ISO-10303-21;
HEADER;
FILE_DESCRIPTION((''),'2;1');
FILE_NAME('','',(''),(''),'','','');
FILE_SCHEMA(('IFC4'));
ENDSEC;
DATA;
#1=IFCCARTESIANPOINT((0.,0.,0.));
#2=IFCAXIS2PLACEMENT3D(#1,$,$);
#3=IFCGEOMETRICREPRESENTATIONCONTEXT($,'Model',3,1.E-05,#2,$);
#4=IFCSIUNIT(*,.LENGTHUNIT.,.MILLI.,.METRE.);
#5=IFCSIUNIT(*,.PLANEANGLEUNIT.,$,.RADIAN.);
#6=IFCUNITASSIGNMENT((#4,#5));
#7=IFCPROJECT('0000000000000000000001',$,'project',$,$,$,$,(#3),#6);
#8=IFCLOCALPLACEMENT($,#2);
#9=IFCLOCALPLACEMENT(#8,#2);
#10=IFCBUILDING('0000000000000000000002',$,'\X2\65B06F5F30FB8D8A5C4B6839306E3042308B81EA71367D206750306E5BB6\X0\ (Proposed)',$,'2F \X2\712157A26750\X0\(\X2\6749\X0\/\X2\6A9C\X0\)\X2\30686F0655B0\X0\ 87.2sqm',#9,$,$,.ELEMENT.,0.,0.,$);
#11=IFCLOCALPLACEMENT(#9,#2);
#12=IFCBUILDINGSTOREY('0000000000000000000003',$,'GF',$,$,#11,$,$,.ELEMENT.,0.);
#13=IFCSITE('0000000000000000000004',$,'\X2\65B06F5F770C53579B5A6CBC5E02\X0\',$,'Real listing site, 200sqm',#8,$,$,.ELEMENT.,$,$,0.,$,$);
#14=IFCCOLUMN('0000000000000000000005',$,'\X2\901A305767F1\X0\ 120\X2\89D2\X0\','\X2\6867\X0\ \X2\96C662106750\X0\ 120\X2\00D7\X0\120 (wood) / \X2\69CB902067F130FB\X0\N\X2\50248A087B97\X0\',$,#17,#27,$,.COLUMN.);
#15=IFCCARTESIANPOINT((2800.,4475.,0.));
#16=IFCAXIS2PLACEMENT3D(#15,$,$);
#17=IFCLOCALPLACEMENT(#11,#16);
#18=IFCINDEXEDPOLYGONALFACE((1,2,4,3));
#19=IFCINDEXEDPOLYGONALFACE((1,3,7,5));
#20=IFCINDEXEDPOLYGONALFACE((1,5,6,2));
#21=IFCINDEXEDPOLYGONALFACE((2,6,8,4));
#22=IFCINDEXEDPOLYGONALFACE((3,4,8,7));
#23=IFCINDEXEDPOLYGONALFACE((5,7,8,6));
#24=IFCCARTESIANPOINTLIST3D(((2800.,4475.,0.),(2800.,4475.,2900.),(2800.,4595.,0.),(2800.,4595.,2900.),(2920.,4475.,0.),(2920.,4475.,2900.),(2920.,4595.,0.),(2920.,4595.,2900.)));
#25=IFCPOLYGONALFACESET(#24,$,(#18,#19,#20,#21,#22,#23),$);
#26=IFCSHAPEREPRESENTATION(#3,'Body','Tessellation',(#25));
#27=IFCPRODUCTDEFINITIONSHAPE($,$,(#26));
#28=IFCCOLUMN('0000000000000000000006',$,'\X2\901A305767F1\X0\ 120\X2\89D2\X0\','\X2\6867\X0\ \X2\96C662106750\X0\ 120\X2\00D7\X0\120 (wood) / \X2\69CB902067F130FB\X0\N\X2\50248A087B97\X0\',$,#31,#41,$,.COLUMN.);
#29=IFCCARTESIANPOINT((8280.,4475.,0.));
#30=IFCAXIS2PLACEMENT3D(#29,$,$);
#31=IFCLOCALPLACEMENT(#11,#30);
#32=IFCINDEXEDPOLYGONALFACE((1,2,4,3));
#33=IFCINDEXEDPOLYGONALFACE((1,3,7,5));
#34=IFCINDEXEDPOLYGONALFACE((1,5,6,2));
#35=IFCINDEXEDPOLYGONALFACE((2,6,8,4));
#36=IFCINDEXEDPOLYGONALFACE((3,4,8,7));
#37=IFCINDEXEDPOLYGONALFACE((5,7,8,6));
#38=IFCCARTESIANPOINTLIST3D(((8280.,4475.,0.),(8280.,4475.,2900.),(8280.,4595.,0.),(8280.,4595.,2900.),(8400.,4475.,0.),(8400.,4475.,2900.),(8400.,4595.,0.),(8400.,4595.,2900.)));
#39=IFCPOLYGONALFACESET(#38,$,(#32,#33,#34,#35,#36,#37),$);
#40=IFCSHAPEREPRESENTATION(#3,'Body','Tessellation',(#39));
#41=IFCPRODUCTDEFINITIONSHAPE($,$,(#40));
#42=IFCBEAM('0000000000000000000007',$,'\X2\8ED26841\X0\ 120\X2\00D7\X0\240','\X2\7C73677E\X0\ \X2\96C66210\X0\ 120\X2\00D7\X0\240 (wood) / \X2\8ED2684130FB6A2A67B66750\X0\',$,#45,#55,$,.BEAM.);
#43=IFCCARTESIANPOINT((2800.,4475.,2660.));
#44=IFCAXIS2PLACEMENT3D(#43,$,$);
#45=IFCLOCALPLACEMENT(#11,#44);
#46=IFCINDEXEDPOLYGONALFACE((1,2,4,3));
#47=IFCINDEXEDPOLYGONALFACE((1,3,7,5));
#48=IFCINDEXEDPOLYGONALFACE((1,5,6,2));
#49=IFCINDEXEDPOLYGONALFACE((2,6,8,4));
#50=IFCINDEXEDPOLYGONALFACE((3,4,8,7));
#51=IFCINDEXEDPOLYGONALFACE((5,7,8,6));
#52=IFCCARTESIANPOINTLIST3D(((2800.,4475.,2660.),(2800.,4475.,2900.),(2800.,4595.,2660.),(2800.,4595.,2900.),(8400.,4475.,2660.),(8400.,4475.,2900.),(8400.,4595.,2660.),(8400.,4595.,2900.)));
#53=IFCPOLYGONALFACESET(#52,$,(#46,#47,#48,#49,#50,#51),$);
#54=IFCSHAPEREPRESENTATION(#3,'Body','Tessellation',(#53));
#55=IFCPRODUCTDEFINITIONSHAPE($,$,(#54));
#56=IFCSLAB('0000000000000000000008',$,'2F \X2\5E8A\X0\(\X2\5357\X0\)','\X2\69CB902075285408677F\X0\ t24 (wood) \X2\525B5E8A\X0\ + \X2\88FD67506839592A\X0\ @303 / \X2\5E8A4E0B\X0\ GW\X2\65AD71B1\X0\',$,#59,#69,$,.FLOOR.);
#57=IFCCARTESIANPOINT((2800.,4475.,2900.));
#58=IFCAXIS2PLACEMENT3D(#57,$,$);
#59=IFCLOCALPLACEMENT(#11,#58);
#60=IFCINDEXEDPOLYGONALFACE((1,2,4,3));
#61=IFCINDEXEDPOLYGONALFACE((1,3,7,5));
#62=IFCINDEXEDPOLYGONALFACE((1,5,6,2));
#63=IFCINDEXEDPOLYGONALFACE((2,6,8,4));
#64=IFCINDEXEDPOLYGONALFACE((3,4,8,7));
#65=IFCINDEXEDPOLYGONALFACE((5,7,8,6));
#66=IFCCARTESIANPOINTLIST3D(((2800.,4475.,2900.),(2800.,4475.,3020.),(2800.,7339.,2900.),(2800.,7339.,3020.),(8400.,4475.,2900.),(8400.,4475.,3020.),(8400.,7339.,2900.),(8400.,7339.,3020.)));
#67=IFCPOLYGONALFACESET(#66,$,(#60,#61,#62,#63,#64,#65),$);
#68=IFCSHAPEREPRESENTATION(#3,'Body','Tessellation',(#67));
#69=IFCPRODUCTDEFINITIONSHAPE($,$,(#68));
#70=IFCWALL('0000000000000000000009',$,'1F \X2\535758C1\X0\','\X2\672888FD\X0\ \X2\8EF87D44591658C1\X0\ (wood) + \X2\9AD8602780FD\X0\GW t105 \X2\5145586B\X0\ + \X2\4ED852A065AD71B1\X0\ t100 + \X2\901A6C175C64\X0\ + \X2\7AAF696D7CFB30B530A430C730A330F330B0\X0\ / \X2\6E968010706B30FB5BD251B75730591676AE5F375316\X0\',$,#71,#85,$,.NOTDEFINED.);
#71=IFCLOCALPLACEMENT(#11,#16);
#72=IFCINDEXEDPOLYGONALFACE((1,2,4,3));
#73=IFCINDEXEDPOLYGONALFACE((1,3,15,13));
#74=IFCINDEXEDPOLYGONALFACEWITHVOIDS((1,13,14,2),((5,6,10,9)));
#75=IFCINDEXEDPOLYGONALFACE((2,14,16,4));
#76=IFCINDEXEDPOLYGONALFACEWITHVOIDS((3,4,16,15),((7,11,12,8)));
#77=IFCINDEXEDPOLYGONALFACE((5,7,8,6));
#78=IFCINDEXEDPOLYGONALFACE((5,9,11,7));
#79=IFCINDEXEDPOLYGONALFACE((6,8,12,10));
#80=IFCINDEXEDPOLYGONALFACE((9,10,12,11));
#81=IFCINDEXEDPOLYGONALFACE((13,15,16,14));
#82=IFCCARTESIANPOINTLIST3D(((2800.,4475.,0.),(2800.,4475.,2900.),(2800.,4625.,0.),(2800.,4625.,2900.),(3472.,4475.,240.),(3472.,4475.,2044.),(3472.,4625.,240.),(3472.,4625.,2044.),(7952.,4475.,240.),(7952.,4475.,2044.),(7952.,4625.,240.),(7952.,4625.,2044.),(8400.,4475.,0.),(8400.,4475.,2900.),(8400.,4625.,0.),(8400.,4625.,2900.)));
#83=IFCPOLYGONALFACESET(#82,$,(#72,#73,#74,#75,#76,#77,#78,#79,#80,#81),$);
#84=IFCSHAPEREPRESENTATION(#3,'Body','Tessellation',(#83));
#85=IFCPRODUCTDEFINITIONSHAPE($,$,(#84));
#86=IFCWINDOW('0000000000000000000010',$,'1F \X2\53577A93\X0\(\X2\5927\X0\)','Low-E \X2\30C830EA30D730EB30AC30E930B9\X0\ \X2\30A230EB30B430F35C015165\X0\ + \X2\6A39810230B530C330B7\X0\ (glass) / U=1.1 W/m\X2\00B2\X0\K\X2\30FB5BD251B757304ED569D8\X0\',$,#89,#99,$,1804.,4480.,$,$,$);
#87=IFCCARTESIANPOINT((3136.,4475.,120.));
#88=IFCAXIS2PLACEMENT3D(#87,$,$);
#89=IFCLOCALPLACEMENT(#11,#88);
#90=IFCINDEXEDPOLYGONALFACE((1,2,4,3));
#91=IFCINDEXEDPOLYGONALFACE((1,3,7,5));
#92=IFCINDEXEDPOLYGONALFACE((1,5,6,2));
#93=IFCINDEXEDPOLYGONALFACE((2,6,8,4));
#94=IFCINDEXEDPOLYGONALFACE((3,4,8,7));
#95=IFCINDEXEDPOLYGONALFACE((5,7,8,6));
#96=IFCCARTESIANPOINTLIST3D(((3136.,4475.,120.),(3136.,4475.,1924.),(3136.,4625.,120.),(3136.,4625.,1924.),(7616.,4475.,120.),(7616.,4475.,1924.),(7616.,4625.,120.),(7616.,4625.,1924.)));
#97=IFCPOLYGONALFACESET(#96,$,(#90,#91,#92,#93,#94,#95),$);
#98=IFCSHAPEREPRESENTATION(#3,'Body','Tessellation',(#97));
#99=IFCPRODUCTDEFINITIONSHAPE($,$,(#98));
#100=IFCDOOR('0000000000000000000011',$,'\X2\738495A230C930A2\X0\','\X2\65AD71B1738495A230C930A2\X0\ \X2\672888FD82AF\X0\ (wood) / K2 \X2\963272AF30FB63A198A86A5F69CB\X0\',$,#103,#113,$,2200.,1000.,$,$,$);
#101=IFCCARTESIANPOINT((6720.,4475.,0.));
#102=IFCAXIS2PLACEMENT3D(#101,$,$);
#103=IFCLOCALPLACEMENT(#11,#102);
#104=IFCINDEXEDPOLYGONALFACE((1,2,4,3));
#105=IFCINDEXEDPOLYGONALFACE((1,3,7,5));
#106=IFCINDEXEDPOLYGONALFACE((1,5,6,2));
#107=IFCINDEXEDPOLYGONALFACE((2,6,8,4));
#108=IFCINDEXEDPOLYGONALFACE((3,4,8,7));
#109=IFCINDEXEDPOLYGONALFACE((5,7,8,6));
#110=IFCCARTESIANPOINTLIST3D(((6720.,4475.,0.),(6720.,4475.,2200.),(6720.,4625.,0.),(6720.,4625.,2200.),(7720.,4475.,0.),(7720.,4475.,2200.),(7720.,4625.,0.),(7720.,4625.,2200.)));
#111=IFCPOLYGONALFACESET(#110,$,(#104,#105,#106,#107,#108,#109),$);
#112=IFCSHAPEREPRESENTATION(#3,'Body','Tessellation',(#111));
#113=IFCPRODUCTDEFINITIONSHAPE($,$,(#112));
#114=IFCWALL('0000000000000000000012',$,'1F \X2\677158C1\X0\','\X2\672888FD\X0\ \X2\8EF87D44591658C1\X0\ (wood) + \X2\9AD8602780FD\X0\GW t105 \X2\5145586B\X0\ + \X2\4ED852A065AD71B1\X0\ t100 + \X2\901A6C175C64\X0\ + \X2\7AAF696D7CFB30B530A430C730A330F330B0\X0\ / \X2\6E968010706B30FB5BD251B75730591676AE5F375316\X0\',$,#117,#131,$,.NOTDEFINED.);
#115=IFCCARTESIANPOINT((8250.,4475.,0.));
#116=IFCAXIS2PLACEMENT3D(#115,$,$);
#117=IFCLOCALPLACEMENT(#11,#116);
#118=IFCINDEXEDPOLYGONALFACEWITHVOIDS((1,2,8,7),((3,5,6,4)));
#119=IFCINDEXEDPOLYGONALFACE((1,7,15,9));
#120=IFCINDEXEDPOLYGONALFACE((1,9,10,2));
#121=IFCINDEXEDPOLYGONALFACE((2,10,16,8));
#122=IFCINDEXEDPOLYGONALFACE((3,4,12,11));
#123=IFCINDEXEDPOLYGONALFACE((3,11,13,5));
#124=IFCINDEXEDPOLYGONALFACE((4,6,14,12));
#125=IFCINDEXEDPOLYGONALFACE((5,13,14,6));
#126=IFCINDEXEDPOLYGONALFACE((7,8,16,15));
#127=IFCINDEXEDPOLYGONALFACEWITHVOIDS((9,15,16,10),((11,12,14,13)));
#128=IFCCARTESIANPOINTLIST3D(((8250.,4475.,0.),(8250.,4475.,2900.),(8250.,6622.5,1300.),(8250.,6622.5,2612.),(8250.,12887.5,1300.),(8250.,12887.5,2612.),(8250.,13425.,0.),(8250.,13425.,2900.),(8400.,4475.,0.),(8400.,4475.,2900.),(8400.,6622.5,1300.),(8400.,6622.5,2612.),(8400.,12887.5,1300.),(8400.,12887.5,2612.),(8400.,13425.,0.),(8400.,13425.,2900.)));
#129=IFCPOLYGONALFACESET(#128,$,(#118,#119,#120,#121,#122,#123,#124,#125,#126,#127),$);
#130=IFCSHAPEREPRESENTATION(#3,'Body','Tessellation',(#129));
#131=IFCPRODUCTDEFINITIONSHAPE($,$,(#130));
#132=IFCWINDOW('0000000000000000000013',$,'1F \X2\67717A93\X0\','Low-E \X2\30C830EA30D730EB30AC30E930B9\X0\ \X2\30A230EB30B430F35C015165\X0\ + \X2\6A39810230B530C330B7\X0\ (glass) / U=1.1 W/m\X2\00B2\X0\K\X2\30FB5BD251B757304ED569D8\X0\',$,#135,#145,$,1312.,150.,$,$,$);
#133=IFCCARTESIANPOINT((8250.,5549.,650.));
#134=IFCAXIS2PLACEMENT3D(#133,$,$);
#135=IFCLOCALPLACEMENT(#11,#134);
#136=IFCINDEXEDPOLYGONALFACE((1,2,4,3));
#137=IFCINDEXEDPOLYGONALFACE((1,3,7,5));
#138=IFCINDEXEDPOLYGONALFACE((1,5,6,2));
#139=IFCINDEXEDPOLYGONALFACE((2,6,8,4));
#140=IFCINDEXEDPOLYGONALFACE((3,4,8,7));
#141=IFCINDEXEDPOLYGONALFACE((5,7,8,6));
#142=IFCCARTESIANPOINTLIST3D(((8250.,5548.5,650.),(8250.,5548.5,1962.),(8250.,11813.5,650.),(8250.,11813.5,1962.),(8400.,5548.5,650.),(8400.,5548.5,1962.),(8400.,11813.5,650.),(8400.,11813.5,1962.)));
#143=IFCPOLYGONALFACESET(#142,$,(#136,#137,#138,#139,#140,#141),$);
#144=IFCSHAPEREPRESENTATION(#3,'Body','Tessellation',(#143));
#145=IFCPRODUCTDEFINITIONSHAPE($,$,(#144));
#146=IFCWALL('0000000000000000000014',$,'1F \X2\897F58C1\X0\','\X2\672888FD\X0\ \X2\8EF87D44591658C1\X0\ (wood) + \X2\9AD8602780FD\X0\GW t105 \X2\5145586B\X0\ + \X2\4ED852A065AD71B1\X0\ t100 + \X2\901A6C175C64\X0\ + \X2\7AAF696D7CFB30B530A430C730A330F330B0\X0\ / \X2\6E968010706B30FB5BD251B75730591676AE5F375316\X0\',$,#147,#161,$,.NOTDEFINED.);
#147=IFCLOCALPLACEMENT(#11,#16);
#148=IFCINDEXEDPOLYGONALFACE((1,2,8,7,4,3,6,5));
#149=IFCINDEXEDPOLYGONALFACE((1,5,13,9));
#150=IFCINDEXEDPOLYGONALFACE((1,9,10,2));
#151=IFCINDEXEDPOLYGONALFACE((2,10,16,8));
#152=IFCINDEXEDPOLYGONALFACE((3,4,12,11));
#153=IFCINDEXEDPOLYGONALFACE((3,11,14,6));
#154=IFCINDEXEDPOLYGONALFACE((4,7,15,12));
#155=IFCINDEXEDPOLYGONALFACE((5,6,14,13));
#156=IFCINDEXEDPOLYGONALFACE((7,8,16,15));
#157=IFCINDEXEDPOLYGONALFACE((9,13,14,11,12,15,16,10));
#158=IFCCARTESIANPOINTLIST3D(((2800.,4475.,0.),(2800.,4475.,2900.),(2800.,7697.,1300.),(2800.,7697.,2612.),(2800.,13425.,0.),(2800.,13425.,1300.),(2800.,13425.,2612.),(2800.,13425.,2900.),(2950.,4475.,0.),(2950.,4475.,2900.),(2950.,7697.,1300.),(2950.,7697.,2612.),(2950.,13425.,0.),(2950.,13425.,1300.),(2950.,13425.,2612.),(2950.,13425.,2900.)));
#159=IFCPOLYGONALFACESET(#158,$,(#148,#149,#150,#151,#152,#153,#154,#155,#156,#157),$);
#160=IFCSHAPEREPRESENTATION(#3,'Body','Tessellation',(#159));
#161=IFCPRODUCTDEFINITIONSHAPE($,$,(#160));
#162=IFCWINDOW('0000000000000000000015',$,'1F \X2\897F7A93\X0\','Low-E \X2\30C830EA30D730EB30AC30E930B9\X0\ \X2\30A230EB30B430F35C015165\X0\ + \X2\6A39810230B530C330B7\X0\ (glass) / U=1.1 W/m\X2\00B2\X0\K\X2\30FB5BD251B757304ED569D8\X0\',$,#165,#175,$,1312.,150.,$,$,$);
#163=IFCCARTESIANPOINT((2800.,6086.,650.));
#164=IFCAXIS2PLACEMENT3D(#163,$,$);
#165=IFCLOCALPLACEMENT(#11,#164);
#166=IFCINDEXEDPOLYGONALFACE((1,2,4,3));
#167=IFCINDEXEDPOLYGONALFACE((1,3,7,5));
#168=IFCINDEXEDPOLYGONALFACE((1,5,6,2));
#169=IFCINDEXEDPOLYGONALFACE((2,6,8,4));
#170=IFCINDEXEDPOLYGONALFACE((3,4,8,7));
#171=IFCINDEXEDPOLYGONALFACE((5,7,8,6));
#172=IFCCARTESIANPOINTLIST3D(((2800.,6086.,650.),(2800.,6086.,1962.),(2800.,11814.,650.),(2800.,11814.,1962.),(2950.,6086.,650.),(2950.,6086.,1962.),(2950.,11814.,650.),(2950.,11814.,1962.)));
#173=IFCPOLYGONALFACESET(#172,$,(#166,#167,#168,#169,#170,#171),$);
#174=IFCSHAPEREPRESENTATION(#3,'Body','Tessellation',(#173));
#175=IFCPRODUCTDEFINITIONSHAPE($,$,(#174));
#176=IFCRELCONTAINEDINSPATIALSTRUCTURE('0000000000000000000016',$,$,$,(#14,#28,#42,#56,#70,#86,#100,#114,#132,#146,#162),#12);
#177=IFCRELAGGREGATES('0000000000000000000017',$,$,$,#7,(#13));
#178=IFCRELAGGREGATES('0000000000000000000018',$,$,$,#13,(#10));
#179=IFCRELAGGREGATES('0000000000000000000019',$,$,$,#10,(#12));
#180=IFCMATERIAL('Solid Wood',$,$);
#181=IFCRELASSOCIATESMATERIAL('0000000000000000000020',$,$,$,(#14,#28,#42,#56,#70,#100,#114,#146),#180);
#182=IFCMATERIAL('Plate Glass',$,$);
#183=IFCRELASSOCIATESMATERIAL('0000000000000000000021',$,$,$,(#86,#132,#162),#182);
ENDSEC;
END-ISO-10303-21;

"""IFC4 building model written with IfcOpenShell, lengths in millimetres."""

from ifc_helpers import new_model, si_unit, frame, frame_2d, origin, place, context, project, spatial, rectangle, extrude, material, element, fill, save


model = new_model("IFC4")

# Units and contexts
model_context = context("Model", 3, precision=1e-05, world=origin())
ifc_project = project(units=[si_unit("LENGTHUNIT", "METRE", prefix="MILLI"), si_unit("PLANEANGLEUNIT", "RADIAN")], contexts=[model_context])

# Site, building, storey
site_placement = place(None, origin())
site = spatial("IfcSite", under=ifc_project, at=site_placement, Name="新潟県南魚沼市", ObjectType="Real listing site, 200sqm", CompositionType="ELEMENT", RefElevation=0.0)
building_placement = place(site_placement, origin())
building = spatial("IfcBuilding", under=site, at=building_placement, Name="新潟・越屋根のある自然素材の家 (Proposed)", ObjectType="2F 無垢材(杉/檜)と漆喰 87.2sqm", CompositionType="ELEMENT", ElevationOfRefHeight=0.0, ElevationOfTerrain=0.0)
storey_placement = place(building_placement, origin())
storey = spatial("IfcBuildingStorey", under=building, at=storey_placement, Name="GF", CompositionType="ELEMENT", Elevation=0.0)

# Columns
ifc_material_1 = material(Name="Solid Wood")
column_1_placement = place(storey_placement, frame((2800.0, 4475.0, 0.0)))
element("IfcColumn", 1, at=column_1_placement, inside=storey, material=ifc_material_1, Name="通し柱 120角", Description="桧 集成材 120×120 (wood) / 構造柱・N値計算", PredefinedType="COLUMN", context=model_context, shape_type="SweptSolid", body=[
    extrude(rectangle(XDim=120.0, YDim=120.0, at=frame_2d((60.0, 60.0))), frame((2800.0, 4475.0, 0.0)), (0.0, 0.0, 1.0), 2900.0),
])
column_2_placement = place(storey_placement, frame((8280.0, 4475.0, 0.0)))
element("IfcColumn", 2, at=column_2_placement, inside=storey, material=ifc_material_1, Name="通し柱 120角", Description="桧 集成材 120×120 (wood) / 構造柱・N値計算", PredefinedType="COLUMN", context=model_context, shape_type="SweptSolid", body=[
    extrude(rectangle(XDim=120.0, YDim=120.0, at=frame_2d((60.0, 60.0))), frame((8280.0, 4475.0, 0.0)), (0.0, 0.0, 1.0), 2900.0),
])

# Beam
beam_1_placement = place(storey_placement, frame((2800.0, 4475.0, 2660.0)))
element("IfcBeam", 3, at=beam_1_placement, inside=storey, material=ifc_material_1, Name="軒桁 120×240", Description="米松 集成 120×240 (wood) / 軒桁・横架材", PredefinedType="BEAM", context=model_context, shape_type="SweptSolid", body=[
    extrude(rectangle(XDim=5600.0, YDim=120.0, at=frame_2d((2800.0, 60.0))), frame((2800.0, 4475.0, 2660.0)), (0.0, 0.0, 1.0), 240.0),
])

# Slab
slab_1_placement = place(storey_placement, frame((2800.0, 4475.0, 2900.0)))
element("IfcSlab", 4, at=slab_1_placement, inside=storey, material=ifc_material_1, Name="2F 床(南)", Description="構造用合板 t24 (wood) 剛床 + 製材根太 @303 / 床下 GW断熱", PredefinedType="FLOOR", context=model_context, shape_type="SweptSolid", body=[
    extrude(rectangle(XDim=5600.0, YDim=2864.0, at=frame_2d((2800.0, 1432.0))), frame((2800.0, 4475.0, 2900.0)), (0.0, 0.0, 1.0), 120.0),
])

# Wall, openings, window, door
wall_1_placement = place(storey_placement, frame((2800.0, 4475.0, 0.0)))
wall_1 = element("IfcWall", 5, at=wall_1_placement, inside=storey, material=ifc_material_1, Name="1F 南壁", Description="木製 軸組外壁 (wood) + 高性能GW t105 充填 + 付加断熱 t100 + 通気層 + 窯業系サイディング / 準耐火・寒冷地外皮強化", PredefinedType="NOTDEFINED", context=model_context, shape_type="SweptSolid", body=[
    extrude(rectangle(XDim=5600.0, YDim=150.0, at=frame_2d((2800.0, 75.0))), frame((2800.0, 4475.0, 0.0)), (0.0, 0.0, 1.0), 2900.0),
])
opening_1_placement = place(storey_placement, frame((3136.0, 4475.0, 120.0)))
opening_1 = element("IfcOpeningElement", 6, at=opening_1_placement, cuts=wall_1, PredefinedType="NOTDEFINED", context=model_context, shape_type="SweptSolid", body=[
    extrude(rectangle(XDim=4480.0, YDim=150.0, at=frame_2d((2240.0, 75.0))), frame((3136.0, 4475.0, 120.0)), (0.0, 0.0, 1.0), 1804.0),
])
opening_2_placement = place(storey_placement, frame((6720.0, 4475.0, 0.0)))
opening_2 = element("IfcOpeningElement", 7, at=opening_2_placement, cuts=wall_1, PredefinedType="NOTDEFINED", context=model_context, shape_type="SweptSolid", body=[
    extrude(rectangle(XDim=1000.0, YDim=150.0, at=frame_2d((500.0, 75.0))), frame((6720.0, 4475.0, 0.0)), (0.0, 0.0, 1.0), 2200.0),
])
ifc_material_2 = material(Name="Plate Glass")
window_1_placement = place(storey_placement, frame((3136.0, 4475.0, 120.0)))
window_1 = element("IfcWindow", 8, at=window_1_placement, inside=storey, material=ifc_material_2, Name="1F 南窓(大)", Description="Low-E トリプルガラス アルゴン封入 + 樹脂サッシ (glass) / U=1.1 W/m²K・寒冷地仕様", OverallHeight=1804.0, OverallWidth=4480.0, context=model_context, shape_type="SweptSolid", body=[
    extrude(rectangle(XDim=4480.0, YDim=150.0, at=frame_2d((2240.0, 75.0))), frame((3136.0, 4475.0, 120.0)), (0.0, 0.0, 1.0), 1804.0),
])
fill(opening_1, window_1)
door_placement = place(storey_placement, frame((6720.0, 4475.0, 0.0)))
door = element("IfcDoor", 9, at=door_placement, inside=storey, material=ifc_material_1, Name="玄関ドア", Description="断熱玄関ドア 木製芯 (wood) / K2 防犯・採風機構", OverallHeight=2200.0, OverallWidth=1000.0, context=model_context, shape_type="SweptSolid", body=[
    extrude(rectangle(XDim=1000.0, YDim=150.0, at=frame_2d((500.0, 75.0))), frame((6720.0, 4475.0, 0.0)), (0.0, 0.0, 1.0), 2200.0),
])
fill(opening_2, door)

# Walls, openings, windows
wall_2_placement = place(storey_placement, frame((8250.0, 4475.0, 0.0)))
wall_2 = element("IfcWall", 10, at=wall_2_placement, inside=storey, material=ifc_material_1, Name="1F 東壁", Description="木製 軸組外壁 (wood) + 高性能GW t105 充填 + 付加断熱 t100 + 通気層 + 窯業系サイディング / 準耐火・寒冷地外皮強化", PredefinedType="NOTDEFINED", context=model_context, shape_type="SweptSolid", body=[
    extrude(rectangle(XDim=150.0, YDim=8950.0, at=frame_2d((75.0, 4475.0))), frame((8250.0, 4475.0, 0.0)), (0.0, 0.0, 1.0), 2900.0),
])
opening_3_placement = place(storey_placement, frame((8250.0, 5549.0, 650.0)))
opening_3 = element("IfcOpeningElement", 11, at=opening_3_placement, cuts=wall_2, PredefinedType="NOTDEFINED", context=model_context, shape_type="SweptSolid", body=[
    extrude(rectangle(XDim=150.0, YDim=6265.0, at=frame_2d((75.0, 3132.0))), frame((8250.0, 5549.0, 650.0)), (0.0, 0.0, 1.0), 1312.0),
])
window_2_placement = place(storey_placement, frame((8250.0, 5549.0, 650.0)))
window_2 = element("IfcWindow", 12, at=window_2_placement, inside=storey, material=ifc_material_2, Name="1F 東窓", Description="Low-E トリプルガラス アルゴン封入 + 樹脂サッシ (glass) / U=1.1 W/m²K・寒冷地仕様", OverallHeight=1312.0, OverallWidth=150.0, context=model_context, shape_type="SweptSolid", body=[
    extrude(rectangle(XDim=150.0, YDim=6265.0, at=frame_2d((75.0, 3132.0))), frame((8250.0, 5549.0, 650.0)), (0.0, 0.0, 1.0), 1312.0),
])
fill(opening_3, window_2)
wall_3_placement = place(storey_placement, frame((2800.0, 4475.0, 0.0)))
wall_3 = element("IfcWall", 13, at=wall_3_placement, inside=storey, material=ifc_material_1, Name="1F 西壁", Description="木製 軸組外壁 (wood) + 高性能GW t105 充填 + 付加断熱 t100 + 通気層 + 窯業系サイディング / 準耐火・寒冷地外皮強化", PredefinedType="NOTDEFINED", context=model_context, shape_type="SweptSolid", body=[
    extrude(rectangle(XDim=150.0, YDim=8950.0, at=frame_2d((75.0, 4475.0))), frame((2800.0, 4475.0, 0.0)), (0.0, 0.0, 1.0), 2900.0),
])
opening_4_placement = place(storey_placement, frame((2800.0, 6086.0, 650.0)))
opening_4 = element("IfcOpeningElement", 14, at=opening_4_placement, cuts=wall_3, PredefinedType="NOTDEFINED", context=model_context, shape_type="SweptSolid", body=[
    extrude(rectangle(XDim=150.0, YDim=5728.0, at=frame_2d((75.0, 2864.0))), frame((2800.0, 6086.0, 650.0)), (0.0, 0.0, 1.0), 1312.0),
])
window_3_placement = place(storey_placement, frame((2800.0, 6086.0, 650.0)))
window_3 = element("IfcWindow", 15, at=window_3_placement, inside=storey, material=ifc_material_2, Name="1F 西窓", Description="Low-E トリプルガラス アルゴン封入 + 樹脂サッシ (glass) / U=1.1 W/m²K・寒冷地仕様", OverallHeight=1312.0, OverallWidth=150.0, context=model_context, shape_type="SweptSolid", body=[
    extrude(rectangle(XDim=150.0, YDim=5728.0, at=frame_2d((75.0, 2864.0))), frame((2800.0, 6086.0, 650.0)), (0.0, 0.0, 1.0), 1312.0),
])
fill(opening_4, window_3)

save(model, "model.ifc")
